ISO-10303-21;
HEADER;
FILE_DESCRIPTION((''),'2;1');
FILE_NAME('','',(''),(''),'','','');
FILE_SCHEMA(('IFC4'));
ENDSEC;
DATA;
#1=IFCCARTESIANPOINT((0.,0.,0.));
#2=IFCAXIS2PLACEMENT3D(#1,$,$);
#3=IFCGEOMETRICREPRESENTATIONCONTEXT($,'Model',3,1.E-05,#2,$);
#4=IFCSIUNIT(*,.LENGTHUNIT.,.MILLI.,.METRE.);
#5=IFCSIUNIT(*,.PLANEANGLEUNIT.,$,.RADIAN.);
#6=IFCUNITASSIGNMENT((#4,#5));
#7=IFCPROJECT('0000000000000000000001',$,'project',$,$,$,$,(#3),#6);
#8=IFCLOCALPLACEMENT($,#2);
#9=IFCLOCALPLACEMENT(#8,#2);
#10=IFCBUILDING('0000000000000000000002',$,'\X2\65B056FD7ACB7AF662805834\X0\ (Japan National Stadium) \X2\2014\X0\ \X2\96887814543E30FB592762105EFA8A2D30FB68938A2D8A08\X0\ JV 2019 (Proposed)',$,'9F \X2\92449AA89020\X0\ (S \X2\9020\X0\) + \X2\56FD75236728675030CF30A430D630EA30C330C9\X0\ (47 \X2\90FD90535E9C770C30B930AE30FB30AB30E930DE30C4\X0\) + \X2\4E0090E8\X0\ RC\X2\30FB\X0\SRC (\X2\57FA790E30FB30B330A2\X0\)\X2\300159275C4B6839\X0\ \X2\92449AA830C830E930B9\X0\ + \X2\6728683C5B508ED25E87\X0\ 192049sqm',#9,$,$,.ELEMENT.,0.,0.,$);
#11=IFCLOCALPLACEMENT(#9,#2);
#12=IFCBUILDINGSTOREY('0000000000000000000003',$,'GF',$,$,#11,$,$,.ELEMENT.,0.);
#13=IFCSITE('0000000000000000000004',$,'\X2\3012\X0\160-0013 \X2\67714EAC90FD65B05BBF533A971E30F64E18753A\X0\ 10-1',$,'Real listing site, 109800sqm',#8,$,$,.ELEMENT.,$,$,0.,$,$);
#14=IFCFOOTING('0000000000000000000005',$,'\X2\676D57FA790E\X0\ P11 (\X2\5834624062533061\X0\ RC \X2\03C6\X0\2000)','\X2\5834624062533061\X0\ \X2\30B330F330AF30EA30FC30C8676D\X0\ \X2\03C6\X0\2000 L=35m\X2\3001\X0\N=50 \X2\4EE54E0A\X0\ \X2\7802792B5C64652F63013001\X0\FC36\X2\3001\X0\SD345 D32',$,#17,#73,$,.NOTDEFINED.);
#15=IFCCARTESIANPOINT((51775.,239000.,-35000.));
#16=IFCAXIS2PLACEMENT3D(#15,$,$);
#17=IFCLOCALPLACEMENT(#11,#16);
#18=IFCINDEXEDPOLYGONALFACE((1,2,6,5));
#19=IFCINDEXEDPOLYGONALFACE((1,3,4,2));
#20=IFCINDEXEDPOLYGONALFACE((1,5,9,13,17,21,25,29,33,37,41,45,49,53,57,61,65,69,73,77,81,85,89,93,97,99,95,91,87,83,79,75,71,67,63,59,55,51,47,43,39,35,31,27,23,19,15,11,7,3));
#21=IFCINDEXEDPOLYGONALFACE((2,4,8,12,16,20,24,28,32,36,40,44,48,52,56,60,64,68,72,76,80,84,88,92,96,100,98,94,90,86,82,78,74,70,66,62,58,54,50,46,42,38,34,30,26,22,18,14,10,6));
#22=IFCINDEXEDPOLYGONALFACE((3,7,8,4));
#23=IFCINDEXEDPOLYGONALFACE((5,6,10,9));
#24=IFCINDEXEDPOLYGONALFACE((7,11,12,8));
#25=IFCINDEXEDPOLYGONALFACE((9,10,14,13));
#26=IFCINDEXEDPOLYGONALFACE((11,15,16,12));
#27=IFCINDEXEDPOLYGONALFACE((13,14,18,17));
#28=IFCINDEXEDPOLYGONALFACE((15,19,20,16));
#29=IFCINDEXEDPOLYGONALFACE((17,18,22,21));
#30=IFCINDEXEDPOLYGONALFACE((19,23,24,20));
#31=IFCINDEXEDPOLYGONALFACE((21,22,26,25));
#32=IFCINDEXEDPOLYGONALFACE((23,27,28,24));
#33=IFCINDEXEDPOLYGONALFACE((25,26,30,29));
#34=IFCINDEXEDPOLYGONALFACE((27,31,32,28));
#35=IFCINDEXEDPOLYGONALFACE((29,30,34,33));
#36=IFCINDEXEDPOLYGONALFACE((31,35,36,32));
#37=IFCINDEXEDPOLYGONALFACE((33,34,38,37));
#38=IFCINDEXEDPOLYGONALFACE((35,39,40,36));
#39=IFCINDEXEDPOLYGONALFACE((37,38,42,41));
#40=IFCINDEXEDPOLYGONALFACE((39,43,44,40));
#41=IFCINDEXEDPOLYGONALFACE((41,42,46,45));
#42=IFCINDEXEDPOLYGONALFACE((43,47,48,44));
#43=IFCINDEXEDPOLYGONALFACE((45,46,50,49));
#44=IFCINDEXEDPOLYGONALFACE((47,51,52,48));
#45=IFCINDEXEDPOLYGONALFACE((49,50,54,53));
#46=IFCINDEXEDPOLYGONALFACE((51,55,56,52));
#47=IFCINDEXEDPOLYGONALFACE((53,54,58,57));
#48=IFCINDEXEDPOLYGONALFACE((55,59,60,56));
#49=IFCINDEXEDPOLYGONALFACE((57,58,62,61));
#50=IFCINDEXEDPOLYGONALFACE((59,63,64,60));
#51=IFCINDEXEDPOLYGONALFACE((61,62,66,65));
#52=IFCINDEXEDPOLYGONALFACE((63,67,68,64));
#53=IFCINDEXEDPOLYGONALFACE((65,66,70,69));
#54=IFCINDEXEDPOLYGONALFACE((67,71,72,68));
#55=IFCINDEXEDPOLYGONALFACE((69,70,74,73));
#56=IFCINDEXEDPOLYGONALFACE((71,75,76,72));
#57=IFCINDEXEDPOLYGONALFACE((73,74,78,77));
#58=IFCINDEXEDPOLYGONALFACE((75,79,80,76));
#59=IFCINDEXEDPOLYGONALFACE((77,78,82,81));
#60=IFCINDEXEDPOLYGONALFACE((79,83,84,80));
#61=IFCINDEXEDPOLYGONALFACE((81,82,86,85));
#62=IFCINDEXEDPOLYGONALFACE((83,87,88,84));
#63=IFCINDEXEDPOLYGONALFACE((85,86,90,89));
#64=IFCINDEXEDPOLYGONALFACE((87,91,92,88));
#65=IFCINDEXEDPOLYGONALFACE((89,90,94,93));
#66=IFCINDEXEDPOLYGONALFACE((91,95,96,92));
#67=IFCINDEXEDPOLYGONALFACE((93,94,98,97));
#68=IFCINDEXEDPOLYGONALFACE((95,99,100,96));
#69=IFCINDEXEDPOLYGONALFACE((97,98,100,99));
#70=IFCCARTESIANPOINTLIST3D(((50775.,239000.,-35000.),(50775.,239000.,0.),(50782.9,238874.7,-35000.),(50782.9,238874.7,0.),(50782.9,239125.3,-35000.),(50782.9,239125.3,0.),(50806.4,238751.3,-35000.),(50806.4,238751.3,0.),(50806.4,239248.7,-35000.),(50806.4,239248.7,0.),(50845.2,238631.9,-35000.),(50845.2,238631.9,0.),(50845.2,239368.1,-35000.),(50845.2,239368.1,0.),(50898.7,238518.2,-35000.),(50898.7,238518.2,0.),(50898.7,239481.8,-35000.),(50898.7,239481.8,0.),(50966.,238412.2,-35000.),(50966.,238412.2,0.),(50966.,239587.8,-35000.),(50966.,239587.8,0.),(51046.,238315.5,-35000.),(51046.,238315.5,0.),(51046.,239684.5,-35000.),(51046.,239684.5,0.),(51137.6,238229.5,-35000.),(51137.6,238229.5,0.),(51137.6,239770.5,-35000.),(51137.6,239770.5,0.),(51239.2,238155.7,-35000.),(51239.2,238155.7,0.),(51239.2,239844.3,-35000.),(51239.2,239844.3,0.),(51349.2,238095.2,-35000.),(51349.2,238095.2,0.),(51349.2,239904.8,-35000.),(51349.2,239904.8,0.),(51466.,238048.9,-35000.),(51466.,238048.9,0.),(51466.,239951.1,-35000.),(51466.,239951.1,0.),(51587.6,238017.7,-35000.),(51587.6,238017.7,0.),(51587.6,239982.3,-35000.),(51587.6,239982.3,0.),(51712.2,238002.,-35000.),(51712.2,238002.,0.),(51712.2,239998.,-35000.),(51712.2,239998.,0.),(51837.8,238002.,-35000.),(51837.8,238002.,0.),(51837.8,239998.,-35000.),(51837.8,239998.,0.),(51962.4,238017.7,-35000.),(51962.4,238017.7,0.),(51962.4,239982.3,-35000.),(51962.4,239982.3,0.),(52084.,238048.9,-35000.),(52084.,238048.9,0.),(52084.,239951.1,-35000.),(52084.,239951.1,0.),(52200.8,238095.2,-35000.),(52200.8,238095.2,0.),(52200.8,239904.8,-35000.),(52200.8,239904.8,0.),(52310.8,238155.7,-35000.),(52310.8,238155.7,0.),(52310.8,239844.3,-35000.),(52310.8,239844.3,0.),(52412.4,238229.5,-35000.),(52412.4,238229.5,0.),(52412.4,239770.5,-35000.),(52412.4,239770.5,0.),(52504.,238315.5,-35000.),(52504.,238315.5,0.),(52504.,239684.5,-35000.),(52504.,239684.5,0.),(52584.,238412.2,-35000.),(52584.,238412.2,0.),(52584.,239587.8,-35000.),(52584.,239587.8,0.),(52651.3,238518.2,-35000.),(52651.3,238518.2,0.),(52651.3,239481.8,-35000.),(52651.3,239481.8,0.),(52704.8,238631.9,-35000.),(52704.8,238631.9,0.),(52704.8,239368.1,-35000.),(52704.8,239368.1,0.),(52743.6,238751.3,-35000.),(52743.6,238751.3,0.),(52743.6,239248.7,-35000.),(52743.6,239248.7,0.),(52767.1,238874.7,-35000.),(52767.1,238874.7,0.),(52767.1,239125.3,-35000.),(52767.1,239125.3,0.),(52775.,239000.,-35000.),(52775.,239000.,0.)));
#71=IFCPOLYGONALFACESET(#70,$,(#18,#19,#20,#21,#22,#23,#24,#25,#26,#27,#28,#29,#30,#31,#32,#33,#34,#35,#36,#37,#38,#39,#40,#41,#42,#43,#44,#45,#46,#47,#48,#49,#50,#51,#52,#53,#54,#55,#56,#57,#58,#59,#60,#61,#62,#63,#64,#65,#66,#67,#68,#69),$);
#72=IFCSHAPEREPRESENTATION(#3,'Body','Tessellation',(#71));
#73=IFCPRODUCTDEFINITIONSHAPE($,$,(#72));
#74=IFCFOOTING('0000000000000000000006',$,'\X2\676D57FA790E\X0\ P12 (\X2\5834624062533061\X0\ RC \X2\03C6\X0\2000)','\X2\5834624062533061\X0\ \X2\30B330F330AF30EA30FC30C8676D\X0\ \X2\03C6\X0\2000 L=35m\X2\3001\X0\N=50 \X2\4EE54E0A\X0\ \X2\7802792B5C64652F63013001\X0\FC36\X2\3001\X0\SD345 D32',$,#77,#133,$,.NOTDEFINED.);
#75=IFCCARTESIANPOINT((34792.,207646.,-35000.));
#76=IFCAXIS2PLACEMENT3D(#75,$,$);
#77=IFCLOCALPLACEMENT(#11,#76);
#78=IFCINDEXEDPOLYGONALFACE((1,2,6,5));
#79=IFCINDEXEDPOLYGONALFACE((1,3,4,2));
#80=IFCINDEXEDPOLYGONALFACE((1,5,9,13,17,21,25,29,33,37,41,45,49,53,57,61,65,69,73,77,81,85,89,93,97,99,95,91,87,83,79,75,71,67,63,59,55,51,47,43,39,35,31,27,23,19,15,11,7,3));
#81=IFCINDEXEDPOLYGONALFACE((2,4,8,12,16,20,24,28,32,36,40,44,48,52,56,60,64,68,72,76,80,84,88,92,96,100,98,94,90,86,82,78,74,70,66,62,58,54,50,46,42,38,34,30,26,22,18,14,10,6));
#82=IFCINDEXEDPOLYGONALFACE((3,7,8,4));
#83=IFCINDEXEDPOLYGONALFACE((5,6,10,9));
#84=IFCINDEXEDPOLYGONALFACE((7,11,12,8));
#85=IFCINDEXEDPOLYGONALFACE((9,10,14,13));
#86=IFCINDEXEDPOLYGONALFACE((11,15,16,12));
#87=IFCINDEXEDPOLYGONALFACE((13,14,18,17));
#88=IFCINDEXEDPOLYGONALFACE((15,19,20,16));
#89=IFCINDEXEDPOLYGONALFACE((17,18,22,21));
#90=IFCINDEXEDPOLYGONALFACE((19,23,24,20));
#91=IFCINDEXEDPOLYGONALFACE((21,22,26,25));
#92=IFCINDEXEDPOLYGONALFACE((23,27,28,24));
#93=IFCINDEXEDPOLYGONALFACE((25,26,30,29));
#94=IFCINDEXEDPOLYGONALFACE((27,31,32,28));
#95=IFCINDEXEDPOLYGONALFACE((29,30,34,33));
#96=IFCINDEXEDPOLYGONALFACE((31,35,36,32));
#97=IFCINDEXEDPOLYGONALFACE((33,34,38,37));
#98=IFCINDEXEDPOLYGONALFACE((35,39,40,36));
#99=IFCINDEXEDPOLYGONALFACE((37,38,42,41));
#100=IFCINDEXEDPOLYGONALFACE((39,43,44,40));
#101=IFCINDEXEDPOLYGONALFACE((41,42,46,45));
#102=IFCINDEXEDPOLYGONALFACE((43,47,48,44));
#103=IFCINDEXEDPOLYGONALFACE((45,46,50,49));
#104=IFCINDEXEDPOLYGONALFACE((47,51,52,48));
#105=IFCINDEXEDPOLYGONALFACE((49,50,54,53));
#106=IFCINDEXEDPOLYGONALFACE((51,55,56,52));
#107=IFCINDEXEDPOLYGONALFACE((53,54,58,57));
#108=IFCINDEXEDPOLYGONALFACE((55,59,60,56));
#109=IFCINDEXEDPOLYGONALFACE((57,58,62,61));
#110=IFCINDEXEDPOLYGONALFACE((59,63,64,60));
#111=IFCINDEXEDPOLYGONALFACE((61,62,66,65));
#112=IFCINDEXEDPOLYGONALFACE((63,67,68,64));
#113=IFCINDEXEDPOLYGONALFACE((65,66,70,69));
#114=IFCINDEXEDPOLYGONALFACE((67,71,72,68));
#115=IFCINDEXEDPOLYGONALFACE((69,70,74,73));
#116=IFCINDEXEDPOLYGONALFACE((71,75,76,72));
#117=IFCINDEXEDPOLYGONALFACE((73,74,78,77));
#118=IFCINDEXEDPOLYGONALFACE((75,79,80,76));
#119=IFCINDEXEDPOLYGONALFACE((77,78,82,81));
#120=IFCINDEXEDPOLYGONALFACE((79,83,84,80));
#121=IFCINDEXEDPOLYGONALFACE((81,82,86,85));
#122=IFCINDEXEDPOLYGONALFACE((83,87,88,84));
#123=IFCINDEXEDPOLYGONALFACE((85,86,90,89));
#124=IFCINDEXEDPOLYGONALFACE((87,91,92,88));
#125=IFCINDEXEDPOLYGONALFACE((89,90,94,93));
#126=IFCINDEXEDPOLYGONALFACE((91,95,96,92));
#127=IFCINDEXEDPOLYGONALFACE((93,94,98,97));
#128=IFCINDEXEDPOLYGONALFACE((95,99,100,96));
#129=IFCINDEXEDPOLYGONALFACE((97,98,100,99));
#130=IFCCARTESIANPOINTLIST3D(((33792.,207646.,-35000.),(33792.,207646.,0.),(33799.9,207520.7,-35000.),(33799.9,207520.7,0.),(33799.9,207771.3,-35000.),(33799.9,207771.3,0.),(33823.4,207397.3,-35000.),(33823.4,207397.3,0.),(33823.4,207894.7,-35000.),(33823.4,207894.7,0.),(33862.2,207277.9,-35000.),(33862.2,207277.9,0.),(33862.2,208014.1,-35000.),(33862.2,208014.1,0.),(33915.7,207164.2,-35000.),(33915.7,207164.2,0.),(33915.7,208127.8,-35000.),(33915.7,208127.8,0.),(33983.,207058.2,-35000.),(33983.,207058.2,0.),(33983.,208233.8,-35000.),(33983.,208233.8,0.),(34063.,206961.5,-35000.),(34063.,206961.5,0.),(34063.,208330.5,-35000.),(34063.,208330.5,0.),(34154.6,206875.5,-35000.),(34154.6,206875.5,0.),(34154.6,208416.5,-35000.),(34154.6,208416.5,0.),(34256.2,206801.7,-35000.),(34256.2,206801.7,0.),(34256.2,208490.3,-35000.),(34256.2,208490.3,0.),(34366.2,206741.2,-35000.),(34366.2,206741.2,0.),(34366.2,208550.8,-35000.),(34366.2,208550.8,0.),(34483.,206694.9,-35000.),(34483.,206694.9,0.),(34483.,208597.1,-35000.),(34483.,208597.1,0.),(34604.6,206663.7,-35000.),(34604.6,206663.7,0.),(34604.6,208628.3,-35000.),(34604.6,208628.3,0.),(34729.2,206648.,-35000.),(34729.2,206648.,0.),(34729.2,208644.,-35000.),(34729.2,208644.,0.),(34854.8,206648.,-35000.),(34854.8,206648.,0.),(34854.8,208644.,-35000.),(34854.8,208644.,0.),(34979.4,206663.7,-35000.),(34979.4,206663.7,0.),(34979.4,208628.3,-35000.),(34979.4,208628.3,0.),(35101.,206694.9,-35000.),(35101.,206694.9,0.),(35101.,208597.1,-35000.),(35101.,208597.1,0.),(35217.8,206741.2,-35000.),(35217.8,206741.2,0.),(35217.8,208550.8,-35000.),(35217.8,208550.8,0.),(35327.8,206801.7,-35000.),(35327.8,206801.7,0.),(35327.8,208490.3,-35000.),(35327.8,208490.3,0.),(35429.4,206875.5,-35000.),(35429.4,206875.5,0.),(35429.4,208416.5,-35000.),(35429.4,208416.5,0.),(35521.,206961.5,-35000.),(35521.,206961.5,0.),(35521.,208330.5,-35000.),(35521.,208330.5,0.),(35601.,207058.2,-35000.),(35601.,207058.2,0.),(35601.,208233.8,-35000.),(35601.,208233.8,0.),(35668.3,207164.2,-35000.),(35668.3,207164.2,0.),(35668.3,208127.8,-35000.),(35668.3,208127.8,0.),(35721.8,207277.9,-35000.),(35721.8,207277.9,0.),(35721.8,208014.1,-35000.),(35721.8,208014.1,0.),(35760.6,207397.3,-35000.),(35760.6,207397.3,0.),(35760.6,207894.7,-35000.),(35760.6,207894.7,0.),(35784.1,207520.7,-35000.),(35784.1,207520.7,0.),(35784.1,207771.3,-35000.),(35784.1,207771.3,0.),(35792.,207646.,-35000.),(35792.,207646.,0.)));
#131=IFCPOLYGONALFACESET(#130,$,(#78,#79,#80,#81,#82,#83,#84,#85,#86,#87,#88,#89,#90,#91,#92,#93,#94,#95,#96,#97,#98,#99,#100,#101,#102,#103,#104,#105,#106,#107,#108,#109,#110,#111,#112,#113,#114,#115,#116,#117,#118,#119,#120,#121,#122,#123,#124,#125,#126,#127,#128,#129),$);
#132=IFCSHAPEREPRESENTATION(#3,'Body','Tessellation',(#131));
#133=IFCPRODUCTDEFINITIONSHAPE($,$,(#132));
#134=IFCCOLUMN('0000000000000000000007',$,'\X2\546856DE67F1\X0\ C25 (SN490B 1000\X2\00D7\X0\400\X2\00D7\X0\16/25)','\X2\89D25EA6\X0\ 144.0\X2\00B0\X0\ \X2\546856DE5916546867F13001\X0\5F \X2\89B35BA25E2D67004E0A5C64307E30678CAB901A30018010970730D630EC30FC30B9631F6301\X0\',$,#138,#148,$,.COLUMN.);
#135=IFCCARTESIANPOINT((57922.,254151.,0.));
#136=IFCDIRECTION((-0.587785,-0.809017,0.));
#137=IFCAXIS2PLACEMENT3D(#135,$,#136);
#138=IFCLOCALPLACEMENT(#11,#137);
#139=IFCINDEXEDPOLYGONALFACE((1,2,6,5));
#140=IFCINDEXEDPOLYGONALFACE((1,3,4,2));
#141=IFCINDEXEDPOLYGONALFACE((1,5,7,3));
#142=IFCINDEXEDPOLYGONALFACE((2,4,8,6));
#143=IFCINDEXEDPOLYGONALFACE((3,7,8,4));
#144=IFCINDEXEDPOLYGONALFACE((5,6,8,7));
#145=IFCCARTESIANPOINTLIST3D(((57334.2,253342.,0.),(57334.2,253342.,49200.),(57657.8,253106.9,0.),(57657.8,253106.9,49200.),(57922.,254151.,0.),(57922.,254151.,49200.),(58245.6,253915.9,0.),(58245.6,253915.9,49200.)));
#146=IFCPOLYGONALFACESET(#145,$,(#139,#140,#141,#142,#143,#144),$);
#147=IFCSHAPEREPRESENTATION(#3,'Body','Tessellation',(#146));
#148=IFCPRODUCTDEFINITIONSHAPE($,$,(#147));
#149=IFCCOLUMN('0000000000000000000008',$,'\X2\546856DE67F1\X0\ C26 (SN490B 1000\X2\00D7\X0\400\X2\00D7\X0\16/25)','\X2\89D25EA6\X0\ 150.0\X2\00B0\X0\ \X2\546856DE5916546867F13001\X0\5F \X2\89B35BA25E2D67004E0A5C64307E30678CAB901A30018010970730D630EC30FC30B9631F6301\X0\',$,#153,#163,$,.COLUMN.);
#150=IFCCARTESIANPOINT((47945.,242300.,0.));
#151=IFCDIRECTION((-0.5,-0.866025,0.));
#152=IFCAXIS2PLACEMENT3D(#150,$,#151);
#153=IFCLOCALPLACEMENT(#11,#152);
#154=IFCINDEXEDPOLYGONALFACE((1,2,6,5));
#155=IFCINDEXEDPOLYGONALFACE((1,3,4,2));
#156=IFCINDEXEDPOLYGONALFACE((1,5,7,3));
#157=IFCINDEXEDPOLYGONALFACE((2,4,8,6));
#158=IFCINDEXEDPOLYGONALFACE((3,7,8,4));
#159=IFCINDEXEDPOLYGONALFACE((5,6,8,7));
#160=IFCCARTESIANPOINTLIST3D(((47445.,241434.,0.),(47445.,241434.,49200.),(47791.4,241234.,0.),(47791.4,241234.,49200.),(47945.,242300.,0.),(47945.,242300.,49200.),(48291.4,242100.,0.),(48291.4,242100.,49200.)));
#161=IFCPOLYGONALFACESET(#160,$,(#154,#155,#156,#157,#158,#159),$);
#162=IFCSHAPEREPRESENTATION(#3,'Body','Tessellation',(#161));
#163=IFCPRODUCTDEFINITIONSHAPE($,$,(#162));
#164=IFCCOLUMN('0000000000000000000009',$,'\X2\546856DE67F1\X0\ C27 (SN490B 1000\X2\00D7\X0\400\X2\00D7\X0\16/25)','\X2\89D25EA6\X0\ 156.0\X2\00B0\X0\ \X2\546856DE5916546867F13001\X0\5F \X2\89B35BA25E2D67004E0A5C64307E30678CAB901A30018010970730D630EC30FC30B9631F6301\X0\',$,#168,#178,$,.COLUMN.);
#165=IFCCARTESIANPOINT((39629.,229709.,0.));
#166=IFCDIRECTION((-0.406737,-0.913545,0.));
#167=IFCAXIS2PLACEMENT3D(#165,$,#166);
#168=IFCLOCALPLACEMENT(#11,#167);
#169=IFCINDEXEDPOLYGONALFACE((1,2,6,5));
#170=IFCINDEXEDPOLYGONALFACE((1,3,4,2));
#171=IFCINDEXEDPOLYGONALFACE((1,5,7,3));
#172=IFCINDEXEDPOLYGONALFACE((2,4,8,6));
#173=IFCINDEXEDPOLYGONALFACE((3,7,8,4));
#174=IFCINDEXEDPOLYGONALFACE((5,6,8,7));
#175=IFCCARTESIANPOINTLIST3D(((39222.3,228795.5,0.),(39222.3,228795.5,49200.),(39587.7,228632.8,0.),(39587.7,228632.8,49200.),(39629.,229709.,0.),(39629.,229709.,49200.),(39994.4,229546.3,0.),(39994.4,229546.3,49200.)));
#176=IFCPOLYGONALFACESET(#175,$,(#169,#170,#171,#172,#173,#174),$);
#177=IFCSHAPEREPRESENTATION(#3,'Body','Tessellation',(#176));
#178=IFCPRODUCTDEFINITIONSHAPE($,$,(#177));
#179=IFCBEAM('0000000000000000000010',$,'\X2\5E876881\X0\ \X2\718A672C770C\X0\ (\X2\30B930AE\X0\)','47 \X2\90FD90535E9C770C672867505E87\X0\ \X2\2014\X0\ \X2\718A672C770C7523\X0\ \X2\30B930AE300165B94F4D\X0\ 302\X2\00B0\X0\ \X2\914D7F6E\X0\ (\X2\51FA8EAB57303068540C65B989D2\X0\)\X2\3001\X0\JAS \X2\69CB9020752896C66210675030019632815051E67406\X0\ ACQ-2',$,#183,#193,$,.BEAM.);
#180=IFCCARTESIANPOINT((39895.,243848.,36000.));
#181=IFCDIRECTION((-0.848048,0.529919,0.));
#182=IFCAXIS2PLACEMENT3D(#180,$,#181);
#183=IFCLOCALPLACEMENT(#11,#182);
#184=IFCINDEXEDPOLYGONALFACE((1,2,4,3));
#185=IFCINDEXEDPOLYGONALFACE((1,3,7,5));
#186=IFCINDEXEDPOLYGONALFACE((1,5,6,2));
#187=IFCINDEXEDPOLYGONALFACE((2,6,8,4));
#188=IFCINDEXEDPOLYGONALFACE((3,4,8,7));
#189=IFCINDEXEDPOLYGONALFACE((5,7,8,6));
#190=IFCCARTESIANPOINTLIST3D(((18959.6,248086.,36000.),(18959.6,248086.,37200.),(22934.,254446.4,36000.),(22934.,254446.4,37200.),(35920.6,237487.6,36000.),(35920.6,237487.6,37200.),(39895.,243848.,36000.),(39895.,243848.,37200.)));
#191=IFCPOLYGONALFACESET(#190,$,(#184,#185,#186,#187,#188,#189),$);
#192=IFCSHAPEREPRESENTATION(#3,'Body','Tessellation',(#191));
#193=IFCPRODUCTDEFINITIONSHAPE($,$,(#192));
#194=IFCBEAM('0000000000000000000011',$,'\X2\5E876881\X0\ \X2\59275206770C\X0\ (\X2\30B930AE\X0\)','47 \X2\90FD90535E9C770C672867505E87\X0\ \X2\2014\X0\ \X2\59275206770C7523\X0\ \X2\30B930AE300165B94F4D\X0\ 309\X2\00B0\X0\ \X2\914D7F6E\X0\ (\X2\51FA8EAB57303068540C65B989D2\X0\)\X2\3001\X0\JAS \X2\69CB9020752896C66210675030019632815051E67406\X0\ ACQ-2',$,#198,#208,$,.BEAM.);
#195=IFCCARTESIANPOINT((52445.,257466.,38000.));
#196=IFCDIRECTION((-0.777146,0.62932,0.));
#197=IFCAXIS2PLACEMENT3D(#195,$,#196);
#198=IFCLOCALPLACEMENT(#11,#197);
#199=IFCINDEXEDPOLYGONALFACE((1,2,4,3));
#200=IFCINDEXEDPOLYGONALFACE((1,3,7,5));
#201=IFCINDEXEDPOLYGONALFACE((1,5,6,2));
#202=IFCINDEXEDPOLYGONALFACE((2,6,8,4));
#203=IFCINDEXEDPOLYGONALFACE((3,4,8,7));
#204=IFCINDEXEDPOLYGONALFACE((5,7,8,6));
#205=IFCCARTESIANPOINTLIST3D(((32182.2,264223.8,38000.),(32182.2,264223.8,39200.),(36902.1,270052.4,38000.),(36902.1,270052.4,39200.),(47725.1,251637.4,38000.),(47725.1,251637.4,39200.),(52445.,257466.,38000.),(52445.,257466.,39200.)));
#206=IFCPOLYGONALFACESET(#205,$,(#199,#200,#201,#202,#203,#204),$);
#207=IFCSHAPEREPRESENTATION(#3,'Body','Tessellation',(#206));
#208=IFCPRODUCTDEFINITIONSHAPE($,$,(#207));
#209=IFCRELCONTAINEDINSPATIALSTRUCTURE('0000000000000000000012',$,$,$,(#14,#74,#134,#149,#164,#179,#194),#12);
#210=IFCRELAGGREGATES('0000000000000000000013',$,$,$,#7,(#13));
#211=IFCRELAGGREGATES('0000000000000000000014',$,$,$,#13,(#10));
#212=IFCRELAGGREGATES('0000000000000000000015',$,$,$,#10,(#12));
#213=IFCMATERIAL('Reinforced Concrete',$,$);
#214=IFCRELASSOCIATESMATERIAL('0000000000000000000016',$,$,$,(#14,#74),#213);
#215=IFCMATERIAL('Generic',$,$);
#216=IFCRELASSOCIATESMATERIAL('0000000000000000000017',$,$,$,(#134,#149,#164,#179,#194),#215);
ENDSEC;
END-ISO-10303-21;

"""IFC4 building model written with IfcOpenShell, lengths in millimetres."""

from ifc_helpers import new_model, si_unit, frame, frame_2d, origin, origin_2d, place, context, project, spatial, rectangle, circle, extrude, material, element, save


model = new_model("IFC4")

# Units and contexts
model_context = context("Model", 3, precision=1e-05, world=origin())
ifc_project = project(units=[si_unit("LENGTHUNIT", "METRE", prefix="MILLI"), si_unit("PLANEANGLEUNIT", "RADIAN")], contexts=[model_context])

# Site, building, storey
site_placement = place(None, origin())
site = spatial("IfcSite", under=ifc_project, at=site_placement, Name="〒160-0013 東京都新宿区霞ヶ丘町 10-1", ObjectType="Real listing site, 109800sqm", CompositionType="ELEMENT", RefElevation=0.0)
building_placement = place(site_placement, origin())
building = spatial("IfcBuilding", under=site, at=building_placement, Name="新国立競技場 (Japan National Stadium) — 隈研吾・大成建設・梓設計 JV 2019 (Proposed)", ObjectType="9F 鉄骨造 (S 造) + 国産木材ハイブリッド (47 都道府県スギ・カラマツ) + 一部 RC・SRC (基礎・コア)、大屋根 鉄骨トラス + 木格子軒庇 192049sqm", CompositionType="ELEMENT", ElevationOfRefHeight=0.0, ElevationOfTerrain=0.0)
storey_placement = place(building_placement, origin())
storey = spatial("IfcBuildingStorey", under=building, at=storey_placement, Name="GF", CompositionType="ELEMENT", Elevation=0.0)

# Footings
ifc_material_1 = material(Name="Reinforced Concrete")
footing_1_placement = place(storey_placement, frame((51775.0, 239000.0, -35000.0)))
element("IfcFooting", 1, at=footing_1_placement, inside=storey, material=ifc_material_1, Name="杭基礎 P11 (場所打ち RC φ2000)", Description="場所打ち コンクリート杭 φ2000 L=35m、N=50 以上 砂礫層支持、FC36、SD345 D32", PredefinedType="NOTDEFINED", context=model_context, shape_type="SweptSolid", body=[
    extrude(circle(Radius=1000.0, at=origin_2d()), frame((51775.0, 239000.0, -35000.0)), (0.0, 0.0, 1.0), 35000.0),
])
footing_2_placement = place(storey_placement, frame((34792.0, 207646.0, -35000.0)))
element("IfcFooting", 2, at=footing_2_placement, inside=storey, material=ifc_material_1, Name="杭基礎 P12 (場所打ち RC φ2000)", Description="場所打ち コンクリート杭 φ2000 L=35m、N=50 以上 砂礫層支持、FC36、SD345 D32", PredefinedType="NOTDEFINED", context=model_context, shape_type="SweptSolid", body=[
    extrude(circle(Radius=1000.0, at=origin_2d()), frame((34792.0, 207646.0, -35000.0)), (0.0, 0.0, 1.0), 35000.0),
])

# Columns
ifc_material_2 = material(Name="Generic")
column_1_placement = place(storey_placement, frame((57922.0, 254151.0, 0.0), x_axis=(-0.587785, -0.809017, 0.0)))
element("IfcColumn", 3, at=column_1_placement, inside=storey, material=ifc_material_2, Name="周回柱 C25 (SN490B 1000×400×16/25)", Description="角度 144.0° 周回外周柱、5F 観客席最上層まで貫通、耐震ブレース挟持", PredefinedType="COLUMN", context=model_context, shape_type="SweptSolid", body=[
    extrude(rectangle(XDim=1000.0, YDim=400.0, at=frame_2d((500.0, 200.0))), frame((57922.0, 254151.0, 0.0), x_axis=(-0.587785, -0.809017, 0.0)), (0.0, 0.0, 1.0), 49200.0),
])
column_2_placement = place(storey_placement, frame((47945.0, 242300.0, 0.0), x_axis=(-0.5, -0.866025, 0.0)))
element("IfcColumn", 4, at=column_2_placement, inside=storey, material=ifc_material_2, Name="周回柱 C26 (SN490B 1000×400×16/25)", Description="角度 150.0° 周回外周柱、5F 観客席最上層まで貫通、耐震ブレース挟持", PredefinedType="COLUMN", context=model_context, shape_type="SweptSolid", body=[
    extrude(rectangle(XDim=1000.0, YDim=400.0, at=frame_2d((500.0, 200.0))), frame((47945.0, 242300.0, 0.0), x_axis=(-0.5, -0.866025, 0.0)), (0.0, 0.0, 1.0), 49200.0),
])
column_3_placement = place(storey_placement, frame((39629.0, 229709.0, 0.0), x_axis=(-0.406737, -0.913545, 0.0)))
element("IfcColumn", 5, at=column_3_placement, inside=storey, material=ifc_material_2, Name="周回柱 C27 (SN490B 1000×400×16/25)", Description="角度 156.0° 周回外周柱、5F 観客席最上層まで貫通、耐震ブレース挟持", PredefinedType="COLUMN", context=model_context, shape_type="SweptSolid", body=[
    extrude(rectangle(XDim=1000.0, YDim=400.0, at=frame_2d((500.0, 200.0))), frame((39629.0, 229709.0, 0.0), x_axis=(-0.406737, -0.913545, 0.0)), (0.0, 0.0, 1.0), 49200.0),
])

# Beams
beam_1_placement = place(storey_placement, frame((39895.0, 243848.0, 36000.0), x_axis=(-0.848048, 0.529919, 0.0)))
element("IfcBeam", 6, at=beam_1_placement, inside=storey, material=ifc_material_2, Name="庇梁 熊本県 (スギ)", Description="47 都道府県木材庇 — 熊本県産 スギ、方位 302° 配置 (出身地と同方角)、JAS 構造用集成材、防腐処理 ACQ-2", PredefinedType="BEAM", context=model_context, shape_type="SweptSolid", body=[
    extrude(rectangle(XDim=20000.0, YDim=7500.0, at=frame_2d((10000.0, 3750.0))), frame((39895.0, 243848.0, 36000.0), x_axis=(-0.848048, 0.529919, 0.0)), (0.0, 0.0, 1.0), 1200.0),
])
beam_2_placement = place(storey_placement, frame((52445.0, 257466.0, 38000.0), x_axis=(-0.777146, 0.62932, 0.0)))
element("IfcBeam", 7, at=beam_2_placement, inside=storey, material=ifc_material_2, Name="庇梁 大分県 (スギ)", Description="47 都道府県木材庇 — 大分県産 スギ、方位 309° 配置 (出身地と同方角)、JAS 構造用集成材、防腐処理 ACQ-2", PredefinedType="BEAM", context=model_context, shape_type="SweptSolid", body=[
    extrude(rectangle(XDim=20000.0, YDim=7500.0, at=frame_2d((10000.0, 3750.0))), frame((52445.0, 257466.0, 38000.0), x_axis=(-0.777146, 0.62932, 0.0)), (0.0, 0.0, 1.0), 1200.0),
])

save(model, "model.ifc")
